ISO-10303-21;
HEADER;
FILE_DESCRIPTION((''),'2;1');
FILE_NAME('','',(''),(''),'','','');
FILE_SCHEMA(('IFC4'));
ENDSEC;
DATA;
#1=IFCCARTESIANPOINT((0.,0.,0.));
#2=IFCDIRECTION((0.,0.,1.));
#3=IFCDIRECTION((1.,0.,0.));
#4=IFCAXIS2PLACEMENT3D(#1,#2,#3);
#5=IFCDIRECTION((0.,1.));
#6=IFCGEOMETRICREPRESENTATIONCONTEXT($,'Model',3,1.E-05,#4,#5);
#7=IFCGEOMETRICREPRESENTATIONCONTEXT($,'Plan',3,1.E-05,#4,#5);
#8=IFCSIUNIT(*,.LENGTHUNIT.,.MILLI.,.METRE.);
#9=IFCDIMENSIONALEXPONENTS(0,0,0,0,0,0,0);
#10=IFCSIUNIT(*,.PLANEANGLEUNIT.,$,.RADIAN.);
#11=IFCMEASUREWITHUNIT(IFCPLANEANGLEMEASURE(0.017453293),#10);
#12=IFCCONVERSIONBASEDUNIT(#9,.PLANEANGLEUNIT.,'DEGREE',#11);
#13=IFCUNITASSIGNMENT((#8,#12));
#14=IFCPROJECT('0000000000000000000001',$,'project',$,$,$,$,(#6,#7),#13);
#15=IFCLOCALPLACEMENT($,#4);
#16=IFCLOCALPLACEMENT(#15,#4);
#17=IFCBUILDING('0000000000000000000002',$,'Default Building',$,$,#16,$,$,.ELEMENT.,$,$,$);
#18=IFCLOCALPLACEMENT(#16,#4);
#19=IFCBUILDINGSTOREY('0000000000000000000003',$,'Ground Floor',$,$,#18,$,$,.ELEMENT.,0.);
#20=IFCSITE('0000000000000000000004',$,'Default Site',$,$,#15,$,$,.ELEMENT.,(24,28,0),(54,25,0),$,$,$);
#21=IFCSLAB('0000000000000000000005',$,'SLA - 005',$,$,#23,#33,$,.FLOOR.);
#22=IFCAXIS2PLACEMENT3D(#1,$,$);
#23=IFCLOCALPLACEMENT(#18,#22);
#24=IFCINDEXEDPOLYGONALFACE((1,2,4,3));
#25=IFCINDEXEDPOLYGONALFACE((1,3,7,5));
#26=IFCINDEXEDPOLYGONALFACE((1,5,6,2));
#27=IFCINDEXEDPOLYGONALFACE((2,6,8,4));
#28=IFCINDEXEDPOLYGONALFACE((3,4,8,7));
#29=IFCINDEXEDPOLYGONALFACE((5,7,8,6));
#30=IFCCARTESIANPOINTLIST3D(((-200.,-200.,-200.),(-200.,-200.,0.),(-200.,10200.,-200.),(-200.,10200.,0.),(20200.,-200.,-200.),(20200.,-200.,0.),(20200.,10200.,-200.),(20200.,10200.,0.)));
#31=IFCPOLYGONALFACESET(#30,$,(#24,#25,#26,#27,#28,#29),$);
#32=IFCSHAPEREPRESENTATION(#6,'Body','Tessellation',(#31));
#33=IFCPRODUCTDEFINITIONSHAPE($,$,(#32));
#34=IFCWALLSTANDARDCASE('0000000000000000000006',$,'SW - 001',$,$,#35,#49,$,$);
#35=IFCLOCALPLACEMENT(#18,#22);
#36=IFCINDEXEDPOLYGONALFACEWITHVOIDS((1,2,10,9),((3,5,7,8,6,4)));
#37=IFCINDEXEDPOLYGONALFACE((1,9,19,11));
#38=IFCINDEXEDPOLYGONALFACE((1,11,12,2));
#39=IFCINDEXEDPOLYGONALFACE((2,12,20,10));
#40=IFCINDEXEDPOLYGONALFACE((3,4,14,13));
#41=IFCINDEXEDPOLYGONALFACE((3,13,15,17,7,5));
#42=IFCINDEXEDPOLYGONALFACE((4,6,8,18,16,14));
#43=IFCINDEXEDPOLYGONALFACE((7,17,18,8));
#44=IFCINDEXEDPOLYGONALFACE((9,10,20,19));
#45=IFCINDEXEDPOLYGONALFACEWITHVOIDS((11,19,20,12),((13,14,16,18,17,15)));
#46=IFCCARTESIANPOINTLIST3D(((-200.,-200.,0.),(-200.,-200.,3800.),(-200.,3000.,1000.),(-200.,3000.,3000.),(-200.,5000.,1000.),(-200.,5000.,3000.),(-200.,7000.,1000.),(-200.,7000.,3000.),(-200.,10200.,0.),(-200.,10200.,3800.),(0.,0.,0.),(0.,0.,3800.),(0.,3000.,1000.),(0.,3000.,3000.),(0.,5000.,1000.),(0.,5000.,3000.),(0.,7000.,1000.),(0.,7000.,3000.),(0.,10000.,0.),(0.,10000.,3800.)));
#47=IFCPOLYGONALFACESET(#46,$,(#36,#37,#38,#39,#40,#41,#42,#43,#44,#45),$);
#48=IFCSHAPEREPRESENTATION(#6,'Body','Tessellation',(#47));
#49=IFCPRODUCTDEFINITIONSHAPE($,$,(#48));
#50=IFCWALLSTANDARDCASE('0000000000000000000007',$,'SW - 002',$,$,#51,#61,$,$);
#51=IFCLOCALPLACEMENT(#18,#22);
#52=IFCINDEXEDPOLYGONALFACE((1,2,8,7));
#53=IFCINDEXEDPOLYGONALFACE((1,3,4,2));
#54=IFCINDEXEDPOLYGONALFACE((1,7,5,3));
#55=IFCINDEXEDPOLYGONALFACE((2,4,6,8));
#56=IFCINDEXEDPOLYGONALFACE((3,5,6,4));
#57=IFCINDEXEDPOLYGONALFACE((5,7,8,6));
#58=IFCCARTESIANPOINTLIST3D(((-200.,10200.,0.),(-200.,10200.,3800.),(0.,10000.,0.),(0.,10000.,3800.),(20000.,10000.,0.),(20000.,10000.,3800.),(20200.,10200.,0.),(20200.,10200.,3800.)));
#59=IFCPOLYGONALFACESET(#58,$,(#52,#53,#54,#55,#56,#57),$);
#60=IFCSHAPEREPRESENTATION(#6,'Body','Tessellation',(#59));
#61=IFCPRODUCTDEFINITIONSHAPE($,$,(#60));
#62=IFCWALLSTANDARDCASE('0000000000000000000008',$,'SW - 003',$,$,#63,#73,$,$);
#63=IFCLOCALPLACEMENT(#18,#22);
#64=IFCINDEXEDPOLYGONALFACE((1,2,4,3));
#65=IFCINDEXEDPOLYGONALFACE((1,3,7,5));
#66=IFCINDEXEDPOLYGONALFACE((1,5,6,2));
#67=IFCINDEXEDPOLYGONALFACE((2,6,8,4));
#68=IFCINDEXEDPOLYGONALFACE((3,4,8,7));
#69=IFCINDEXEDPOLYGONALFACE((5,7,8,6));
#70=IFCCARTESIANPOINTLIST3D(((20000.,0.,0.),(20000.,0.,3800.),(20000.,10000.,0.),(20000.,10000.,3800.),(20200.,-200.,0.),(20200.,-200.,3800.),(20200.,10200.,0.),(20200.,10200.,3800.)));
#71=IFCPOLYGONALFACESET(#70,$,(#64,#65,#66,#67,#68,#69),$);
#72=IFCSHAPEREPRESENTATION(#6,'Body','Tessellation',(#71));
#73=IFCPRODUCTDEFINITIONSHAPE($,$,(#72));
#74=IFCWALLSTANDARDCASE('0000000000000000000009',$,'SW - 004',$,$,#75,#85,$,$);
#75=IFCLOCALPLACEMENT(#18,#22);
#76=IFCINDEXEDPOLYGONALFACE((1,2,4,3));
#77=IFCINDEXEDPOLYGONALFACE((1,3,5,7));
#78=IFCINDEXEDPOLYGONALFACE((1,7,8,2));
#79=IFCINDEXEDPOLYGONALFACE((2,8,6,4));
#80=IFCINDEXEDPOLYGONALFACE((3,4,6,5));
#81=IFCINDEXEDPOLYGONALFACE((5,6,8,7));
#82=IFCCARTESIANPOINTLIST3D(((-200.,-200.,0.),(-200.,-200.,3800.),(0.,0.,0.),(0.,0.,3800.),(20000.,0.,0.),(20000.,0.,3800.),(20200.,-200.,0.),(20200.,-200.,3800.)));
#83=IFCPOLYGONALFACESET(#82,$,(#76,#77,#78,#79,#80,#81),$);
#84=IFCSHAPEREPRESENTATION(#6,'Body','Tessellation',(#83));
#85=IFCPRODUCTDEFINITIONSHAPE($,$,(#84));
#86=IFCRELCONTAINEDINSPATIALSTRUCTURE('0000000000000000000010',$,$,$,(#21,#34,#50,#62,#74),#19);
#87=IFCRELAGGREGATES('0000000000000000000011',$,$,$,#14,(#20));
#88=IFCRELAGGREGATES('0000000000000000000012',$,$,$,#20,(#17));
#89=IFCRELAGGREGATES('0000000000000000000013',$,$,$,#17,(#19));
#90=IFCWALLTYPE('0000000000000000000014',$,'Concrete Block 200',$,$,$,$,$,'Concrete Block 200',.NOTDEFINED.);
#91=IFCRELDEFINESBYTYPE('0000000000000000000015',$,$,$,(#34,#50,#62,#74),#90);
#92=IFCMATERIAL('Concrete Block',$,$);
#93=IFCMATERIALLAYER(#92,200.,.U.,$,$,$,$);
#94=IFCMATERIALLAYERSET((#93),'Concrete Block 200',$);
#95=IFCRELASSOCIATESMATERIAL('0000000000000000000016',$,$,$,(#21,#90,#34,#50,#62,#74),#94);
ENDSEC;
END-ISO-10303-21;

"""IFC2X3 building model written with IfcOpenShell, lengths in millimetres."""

from ifc_helpers import new_model, entity, si_unit, converted_unit, direction, frame, origin_with_axes, place, context, project, spatial, polyline, outline, extrude, material, layer, layer_set, layer_usage, type_object, element, save


model = new_model("IFC2X3")

# Units and contexts
model_context = context("Model", 3, precision=1e-05, world=origin_with_axes(), true_north=direction((0.0, 1.0)))
plan_context = context("Plan", 3, precision=1e-05, world=origin_with_axes(), true_north=direction((0.0, 1.0)))
ifc_project = project(units=[si_unit("LENGTHUNIT", "METRE", prefix="MILLI"), converted_unit("PLANEANGLEUNIT", "DEGREE", entity("IfcPlaneAngleMeasure", 0.017453293), si_unit("PLANEANGLEUNIT", "RADIAN"), dimensions=[0, 0, 0, 0, 0, 0, 0])], contexts=[model_context, plan_context])

# Site, building, storey
site_placement = place(None, origin_with_axes())
site = spatial("IfcSite", under=ifc_project, at=site_placement, Name="Default Site", CompositionType="ELEMENT", RefLatitude=(24, 28, 0), RefLongitude=(54, 25, 0))
building_placement = place(site_placement, origin_with_axes())
building = spatial("IfcBuilding", under=site, at=building_placement, Name="Default Building", CompositionType="ELEMENT")
storey_placement = place(building_placement, origin_with_axes())
storey = spatial("IfcBuildingStorey", under=building, at=storey_placement, Name="Ground Floor", CompositionType="ELEMENT", Elevation=0.0)

# Slab
ifc_material = material(Name="Concrete Block")
ifc_layer = layer(ifc_material, 200.0, ventilated="UNKNOWN")
ifc_layer_set = layer_set([ifc_layer], Name="Concrete Block 200")
ifc_layer_usage_1 = layer_usage(ifc_layer_set, "AXIS3", "NEGATIVE", 200.0)
slab_placement = place(storey_placement, frame((-200.0, 10200.0, -200.0), z_axis=(0.0, 0.0, 1.0), x_axis=(1.0, 0.0, 0.0)))
element("IfcSlab", 1, at=slab_placement, inside=storey, material=ifc_layer_usage_1, Name="SLA - 005", PredefinedType="FLOOR", context=model_context, shape_type="SweptSolid", body=[
    extrude(outline(polyline([(0.0, 0.0), (20400.0, 0.0), (20400.0, -10400.0), (0.0, -10400.0), (0.0, 0.0)])), origin_with_axes(), (0.0, 0.0, 1.0), 200.0),
])

# Wall, openings
ifc_layer_usage_2 = layer_usage(ifc_layer_set, "AXIS2", "POSITIVE", 0.0)
wall_type = type_object("IfcWallType", Name="Concrete Block 200", ElementType="Concrete Block 200", PredefinedType="NOTDEFINED", material=ifc_layer_set)
wall_1_placement = place(storey_placement, frame((0.0, 0.0, 0.0), z_axis=(0.0, 0.0, 1.0), x_axis=(0.0, 1.0, 0.0)))
wall_1 = element("IfcWallStandardCase", 2, at=wall_1_placement, inside=storey, type_object=wall_type, material=ifc_layer_usage_2, Name="SW - 001", context=model_context, shape_type="SweptSolid", body=[
    extrude(outline(polyline([(0.0, 0.0), (10000.0, 0.0), (10200.0, 200.0), (-200.0, 200.0), (0.0, 0.0)])), origin_with_axes(), (0.0, 0.0, 1.0), 3800.0),
])
opening_1_placement = place(wall_1_placement, frame((6000.0, 0.0, 1000.0), z_axis=(0.0, 0.0, 1.0), x_axis=(1.0, 0.0, 0.0)))
element("IfcOpeningElement", 3, at=opening_1_placement, cuts=wall_1, ObjectType="Opening", context=model_context, shape_type="SweptSolid", body=[
    extrude(outline(polyline([(-1000.0, 0.0), (1000.0, 0.0), (1000.0, 2000.0), (-1000.0, 2000.0), (-1000.0, 0.0)])), frame((0.0, 0.0, 0.0), z_axis=(0.0, 1.0, 0.0), x_axis=(-1.0, 0.0, 0.0)), (0.0, 0.0, 1.0), 200.0),
])
opening_2_placement = place(wall_1_placement, frame((4000.0, 0.0, 1000.0), z_axis=(0.0, 0.0, 1.0), x_axis=(1.0, 0.0, 0.0)))
element("IfcOpeningElement", 4, at=opening_2_placement, cuts=wall_1, ObjectType="Opening", context=model_context, shape_type="SweptSolid", body=[
    extrude(outline(polyline([(-1000.0, 0.0), (1000.0, 0.0), (1000.0, 2000.0), (-1000.0, 2000.0), (-1000.0, 0.0)])), frame((0.0, 0.0, 0.0), z_axis=(0.0, 1.0, 0.0), x_axis=(-1.0, 0.0, 0.0)), (0.0, 0.0, 1.0), 200.0),
])

# Walls
ifc_layer_usage_3 = layer_usage(ifc_layer_set, "AXIS2", "POSITIVE", 0.0)
wall_2_placement = place(storey_placement, frame((0.0, 10000.0, 0.0), z_axis=(0.0, 0.0, 1.0), x_axis=(1.0, 0.0, 0.0)))
element("IfcWallStandardCase", 5, at=wall_2_placement, inside=storey, type_object=wall_type, material=ifc_layer_usage_3, Name="SW - 002", context=model_context, shape_type="SweptSolid", body=[
    extrude(outline(polyline([(0.0, 0.0), (20000.0, 0.0), (20200.0, 200.0), (-200.0, 200.0), (0.0, 0.0)])), origin_with_axes(), (0.0, 0.0, 1.0), 3800.0),
])
ifc_layer_usage_4 = layer_usage(ifc_layer_set, "AXIS2", "POSITIVE", 0.0)
wall_3_placement = place(storey_placement, frame((20000.0, 10000.0, 0.0), z_axis=(0.0, 0.0, 1.0), x_axis=(0.0, -1.0, 0.0)))
element("IfcWallStandardCase", 6, at=wall_3_placement, inside=storey, type_object=wall_type, material=ifc_layer_usage_4, Name="SW - 003", context=model_context, shape_type="SweptSolid", body=[
    extrude(outline(polyline([(0.0, 0.0), (10000.0, 0.0), (10200.0, 200.0), (-200.0, 200.0), (0.0, 0.0)])), origin_with_axes(), (0.0, 0.0, 1.0), 3800.0),
])
ifc_layer_usage_5 = layer_usage(ifc_layer_set, "AXIS2", "POSITIVE", 0.0)
wall_4_placement = place(storey_placement, frame((20000.0, 0.0, 0.0), z_axis=(0.0, 0.0, 1.0), x_axis=(-1.0, 0.0, 0.0)))
element("IfcWallStandardCase", 7, at=wall_4_placement, inside=storey, type_object=wall_type, material=ifc_layer_usage_5, Name="SW - 004", context=model_context, shape_type="SweptSolid", body=[
    extrude(outline(polyline([(0.0, 0.0), (20000.0, 0.0), (20200.0, 200.0), (-200.0, 200.0), (0.0, 0.0)])), origin_with_axes(), (0.0, 0.0, 1.0), 3800.0),
])

save(model, "model.ifc")
